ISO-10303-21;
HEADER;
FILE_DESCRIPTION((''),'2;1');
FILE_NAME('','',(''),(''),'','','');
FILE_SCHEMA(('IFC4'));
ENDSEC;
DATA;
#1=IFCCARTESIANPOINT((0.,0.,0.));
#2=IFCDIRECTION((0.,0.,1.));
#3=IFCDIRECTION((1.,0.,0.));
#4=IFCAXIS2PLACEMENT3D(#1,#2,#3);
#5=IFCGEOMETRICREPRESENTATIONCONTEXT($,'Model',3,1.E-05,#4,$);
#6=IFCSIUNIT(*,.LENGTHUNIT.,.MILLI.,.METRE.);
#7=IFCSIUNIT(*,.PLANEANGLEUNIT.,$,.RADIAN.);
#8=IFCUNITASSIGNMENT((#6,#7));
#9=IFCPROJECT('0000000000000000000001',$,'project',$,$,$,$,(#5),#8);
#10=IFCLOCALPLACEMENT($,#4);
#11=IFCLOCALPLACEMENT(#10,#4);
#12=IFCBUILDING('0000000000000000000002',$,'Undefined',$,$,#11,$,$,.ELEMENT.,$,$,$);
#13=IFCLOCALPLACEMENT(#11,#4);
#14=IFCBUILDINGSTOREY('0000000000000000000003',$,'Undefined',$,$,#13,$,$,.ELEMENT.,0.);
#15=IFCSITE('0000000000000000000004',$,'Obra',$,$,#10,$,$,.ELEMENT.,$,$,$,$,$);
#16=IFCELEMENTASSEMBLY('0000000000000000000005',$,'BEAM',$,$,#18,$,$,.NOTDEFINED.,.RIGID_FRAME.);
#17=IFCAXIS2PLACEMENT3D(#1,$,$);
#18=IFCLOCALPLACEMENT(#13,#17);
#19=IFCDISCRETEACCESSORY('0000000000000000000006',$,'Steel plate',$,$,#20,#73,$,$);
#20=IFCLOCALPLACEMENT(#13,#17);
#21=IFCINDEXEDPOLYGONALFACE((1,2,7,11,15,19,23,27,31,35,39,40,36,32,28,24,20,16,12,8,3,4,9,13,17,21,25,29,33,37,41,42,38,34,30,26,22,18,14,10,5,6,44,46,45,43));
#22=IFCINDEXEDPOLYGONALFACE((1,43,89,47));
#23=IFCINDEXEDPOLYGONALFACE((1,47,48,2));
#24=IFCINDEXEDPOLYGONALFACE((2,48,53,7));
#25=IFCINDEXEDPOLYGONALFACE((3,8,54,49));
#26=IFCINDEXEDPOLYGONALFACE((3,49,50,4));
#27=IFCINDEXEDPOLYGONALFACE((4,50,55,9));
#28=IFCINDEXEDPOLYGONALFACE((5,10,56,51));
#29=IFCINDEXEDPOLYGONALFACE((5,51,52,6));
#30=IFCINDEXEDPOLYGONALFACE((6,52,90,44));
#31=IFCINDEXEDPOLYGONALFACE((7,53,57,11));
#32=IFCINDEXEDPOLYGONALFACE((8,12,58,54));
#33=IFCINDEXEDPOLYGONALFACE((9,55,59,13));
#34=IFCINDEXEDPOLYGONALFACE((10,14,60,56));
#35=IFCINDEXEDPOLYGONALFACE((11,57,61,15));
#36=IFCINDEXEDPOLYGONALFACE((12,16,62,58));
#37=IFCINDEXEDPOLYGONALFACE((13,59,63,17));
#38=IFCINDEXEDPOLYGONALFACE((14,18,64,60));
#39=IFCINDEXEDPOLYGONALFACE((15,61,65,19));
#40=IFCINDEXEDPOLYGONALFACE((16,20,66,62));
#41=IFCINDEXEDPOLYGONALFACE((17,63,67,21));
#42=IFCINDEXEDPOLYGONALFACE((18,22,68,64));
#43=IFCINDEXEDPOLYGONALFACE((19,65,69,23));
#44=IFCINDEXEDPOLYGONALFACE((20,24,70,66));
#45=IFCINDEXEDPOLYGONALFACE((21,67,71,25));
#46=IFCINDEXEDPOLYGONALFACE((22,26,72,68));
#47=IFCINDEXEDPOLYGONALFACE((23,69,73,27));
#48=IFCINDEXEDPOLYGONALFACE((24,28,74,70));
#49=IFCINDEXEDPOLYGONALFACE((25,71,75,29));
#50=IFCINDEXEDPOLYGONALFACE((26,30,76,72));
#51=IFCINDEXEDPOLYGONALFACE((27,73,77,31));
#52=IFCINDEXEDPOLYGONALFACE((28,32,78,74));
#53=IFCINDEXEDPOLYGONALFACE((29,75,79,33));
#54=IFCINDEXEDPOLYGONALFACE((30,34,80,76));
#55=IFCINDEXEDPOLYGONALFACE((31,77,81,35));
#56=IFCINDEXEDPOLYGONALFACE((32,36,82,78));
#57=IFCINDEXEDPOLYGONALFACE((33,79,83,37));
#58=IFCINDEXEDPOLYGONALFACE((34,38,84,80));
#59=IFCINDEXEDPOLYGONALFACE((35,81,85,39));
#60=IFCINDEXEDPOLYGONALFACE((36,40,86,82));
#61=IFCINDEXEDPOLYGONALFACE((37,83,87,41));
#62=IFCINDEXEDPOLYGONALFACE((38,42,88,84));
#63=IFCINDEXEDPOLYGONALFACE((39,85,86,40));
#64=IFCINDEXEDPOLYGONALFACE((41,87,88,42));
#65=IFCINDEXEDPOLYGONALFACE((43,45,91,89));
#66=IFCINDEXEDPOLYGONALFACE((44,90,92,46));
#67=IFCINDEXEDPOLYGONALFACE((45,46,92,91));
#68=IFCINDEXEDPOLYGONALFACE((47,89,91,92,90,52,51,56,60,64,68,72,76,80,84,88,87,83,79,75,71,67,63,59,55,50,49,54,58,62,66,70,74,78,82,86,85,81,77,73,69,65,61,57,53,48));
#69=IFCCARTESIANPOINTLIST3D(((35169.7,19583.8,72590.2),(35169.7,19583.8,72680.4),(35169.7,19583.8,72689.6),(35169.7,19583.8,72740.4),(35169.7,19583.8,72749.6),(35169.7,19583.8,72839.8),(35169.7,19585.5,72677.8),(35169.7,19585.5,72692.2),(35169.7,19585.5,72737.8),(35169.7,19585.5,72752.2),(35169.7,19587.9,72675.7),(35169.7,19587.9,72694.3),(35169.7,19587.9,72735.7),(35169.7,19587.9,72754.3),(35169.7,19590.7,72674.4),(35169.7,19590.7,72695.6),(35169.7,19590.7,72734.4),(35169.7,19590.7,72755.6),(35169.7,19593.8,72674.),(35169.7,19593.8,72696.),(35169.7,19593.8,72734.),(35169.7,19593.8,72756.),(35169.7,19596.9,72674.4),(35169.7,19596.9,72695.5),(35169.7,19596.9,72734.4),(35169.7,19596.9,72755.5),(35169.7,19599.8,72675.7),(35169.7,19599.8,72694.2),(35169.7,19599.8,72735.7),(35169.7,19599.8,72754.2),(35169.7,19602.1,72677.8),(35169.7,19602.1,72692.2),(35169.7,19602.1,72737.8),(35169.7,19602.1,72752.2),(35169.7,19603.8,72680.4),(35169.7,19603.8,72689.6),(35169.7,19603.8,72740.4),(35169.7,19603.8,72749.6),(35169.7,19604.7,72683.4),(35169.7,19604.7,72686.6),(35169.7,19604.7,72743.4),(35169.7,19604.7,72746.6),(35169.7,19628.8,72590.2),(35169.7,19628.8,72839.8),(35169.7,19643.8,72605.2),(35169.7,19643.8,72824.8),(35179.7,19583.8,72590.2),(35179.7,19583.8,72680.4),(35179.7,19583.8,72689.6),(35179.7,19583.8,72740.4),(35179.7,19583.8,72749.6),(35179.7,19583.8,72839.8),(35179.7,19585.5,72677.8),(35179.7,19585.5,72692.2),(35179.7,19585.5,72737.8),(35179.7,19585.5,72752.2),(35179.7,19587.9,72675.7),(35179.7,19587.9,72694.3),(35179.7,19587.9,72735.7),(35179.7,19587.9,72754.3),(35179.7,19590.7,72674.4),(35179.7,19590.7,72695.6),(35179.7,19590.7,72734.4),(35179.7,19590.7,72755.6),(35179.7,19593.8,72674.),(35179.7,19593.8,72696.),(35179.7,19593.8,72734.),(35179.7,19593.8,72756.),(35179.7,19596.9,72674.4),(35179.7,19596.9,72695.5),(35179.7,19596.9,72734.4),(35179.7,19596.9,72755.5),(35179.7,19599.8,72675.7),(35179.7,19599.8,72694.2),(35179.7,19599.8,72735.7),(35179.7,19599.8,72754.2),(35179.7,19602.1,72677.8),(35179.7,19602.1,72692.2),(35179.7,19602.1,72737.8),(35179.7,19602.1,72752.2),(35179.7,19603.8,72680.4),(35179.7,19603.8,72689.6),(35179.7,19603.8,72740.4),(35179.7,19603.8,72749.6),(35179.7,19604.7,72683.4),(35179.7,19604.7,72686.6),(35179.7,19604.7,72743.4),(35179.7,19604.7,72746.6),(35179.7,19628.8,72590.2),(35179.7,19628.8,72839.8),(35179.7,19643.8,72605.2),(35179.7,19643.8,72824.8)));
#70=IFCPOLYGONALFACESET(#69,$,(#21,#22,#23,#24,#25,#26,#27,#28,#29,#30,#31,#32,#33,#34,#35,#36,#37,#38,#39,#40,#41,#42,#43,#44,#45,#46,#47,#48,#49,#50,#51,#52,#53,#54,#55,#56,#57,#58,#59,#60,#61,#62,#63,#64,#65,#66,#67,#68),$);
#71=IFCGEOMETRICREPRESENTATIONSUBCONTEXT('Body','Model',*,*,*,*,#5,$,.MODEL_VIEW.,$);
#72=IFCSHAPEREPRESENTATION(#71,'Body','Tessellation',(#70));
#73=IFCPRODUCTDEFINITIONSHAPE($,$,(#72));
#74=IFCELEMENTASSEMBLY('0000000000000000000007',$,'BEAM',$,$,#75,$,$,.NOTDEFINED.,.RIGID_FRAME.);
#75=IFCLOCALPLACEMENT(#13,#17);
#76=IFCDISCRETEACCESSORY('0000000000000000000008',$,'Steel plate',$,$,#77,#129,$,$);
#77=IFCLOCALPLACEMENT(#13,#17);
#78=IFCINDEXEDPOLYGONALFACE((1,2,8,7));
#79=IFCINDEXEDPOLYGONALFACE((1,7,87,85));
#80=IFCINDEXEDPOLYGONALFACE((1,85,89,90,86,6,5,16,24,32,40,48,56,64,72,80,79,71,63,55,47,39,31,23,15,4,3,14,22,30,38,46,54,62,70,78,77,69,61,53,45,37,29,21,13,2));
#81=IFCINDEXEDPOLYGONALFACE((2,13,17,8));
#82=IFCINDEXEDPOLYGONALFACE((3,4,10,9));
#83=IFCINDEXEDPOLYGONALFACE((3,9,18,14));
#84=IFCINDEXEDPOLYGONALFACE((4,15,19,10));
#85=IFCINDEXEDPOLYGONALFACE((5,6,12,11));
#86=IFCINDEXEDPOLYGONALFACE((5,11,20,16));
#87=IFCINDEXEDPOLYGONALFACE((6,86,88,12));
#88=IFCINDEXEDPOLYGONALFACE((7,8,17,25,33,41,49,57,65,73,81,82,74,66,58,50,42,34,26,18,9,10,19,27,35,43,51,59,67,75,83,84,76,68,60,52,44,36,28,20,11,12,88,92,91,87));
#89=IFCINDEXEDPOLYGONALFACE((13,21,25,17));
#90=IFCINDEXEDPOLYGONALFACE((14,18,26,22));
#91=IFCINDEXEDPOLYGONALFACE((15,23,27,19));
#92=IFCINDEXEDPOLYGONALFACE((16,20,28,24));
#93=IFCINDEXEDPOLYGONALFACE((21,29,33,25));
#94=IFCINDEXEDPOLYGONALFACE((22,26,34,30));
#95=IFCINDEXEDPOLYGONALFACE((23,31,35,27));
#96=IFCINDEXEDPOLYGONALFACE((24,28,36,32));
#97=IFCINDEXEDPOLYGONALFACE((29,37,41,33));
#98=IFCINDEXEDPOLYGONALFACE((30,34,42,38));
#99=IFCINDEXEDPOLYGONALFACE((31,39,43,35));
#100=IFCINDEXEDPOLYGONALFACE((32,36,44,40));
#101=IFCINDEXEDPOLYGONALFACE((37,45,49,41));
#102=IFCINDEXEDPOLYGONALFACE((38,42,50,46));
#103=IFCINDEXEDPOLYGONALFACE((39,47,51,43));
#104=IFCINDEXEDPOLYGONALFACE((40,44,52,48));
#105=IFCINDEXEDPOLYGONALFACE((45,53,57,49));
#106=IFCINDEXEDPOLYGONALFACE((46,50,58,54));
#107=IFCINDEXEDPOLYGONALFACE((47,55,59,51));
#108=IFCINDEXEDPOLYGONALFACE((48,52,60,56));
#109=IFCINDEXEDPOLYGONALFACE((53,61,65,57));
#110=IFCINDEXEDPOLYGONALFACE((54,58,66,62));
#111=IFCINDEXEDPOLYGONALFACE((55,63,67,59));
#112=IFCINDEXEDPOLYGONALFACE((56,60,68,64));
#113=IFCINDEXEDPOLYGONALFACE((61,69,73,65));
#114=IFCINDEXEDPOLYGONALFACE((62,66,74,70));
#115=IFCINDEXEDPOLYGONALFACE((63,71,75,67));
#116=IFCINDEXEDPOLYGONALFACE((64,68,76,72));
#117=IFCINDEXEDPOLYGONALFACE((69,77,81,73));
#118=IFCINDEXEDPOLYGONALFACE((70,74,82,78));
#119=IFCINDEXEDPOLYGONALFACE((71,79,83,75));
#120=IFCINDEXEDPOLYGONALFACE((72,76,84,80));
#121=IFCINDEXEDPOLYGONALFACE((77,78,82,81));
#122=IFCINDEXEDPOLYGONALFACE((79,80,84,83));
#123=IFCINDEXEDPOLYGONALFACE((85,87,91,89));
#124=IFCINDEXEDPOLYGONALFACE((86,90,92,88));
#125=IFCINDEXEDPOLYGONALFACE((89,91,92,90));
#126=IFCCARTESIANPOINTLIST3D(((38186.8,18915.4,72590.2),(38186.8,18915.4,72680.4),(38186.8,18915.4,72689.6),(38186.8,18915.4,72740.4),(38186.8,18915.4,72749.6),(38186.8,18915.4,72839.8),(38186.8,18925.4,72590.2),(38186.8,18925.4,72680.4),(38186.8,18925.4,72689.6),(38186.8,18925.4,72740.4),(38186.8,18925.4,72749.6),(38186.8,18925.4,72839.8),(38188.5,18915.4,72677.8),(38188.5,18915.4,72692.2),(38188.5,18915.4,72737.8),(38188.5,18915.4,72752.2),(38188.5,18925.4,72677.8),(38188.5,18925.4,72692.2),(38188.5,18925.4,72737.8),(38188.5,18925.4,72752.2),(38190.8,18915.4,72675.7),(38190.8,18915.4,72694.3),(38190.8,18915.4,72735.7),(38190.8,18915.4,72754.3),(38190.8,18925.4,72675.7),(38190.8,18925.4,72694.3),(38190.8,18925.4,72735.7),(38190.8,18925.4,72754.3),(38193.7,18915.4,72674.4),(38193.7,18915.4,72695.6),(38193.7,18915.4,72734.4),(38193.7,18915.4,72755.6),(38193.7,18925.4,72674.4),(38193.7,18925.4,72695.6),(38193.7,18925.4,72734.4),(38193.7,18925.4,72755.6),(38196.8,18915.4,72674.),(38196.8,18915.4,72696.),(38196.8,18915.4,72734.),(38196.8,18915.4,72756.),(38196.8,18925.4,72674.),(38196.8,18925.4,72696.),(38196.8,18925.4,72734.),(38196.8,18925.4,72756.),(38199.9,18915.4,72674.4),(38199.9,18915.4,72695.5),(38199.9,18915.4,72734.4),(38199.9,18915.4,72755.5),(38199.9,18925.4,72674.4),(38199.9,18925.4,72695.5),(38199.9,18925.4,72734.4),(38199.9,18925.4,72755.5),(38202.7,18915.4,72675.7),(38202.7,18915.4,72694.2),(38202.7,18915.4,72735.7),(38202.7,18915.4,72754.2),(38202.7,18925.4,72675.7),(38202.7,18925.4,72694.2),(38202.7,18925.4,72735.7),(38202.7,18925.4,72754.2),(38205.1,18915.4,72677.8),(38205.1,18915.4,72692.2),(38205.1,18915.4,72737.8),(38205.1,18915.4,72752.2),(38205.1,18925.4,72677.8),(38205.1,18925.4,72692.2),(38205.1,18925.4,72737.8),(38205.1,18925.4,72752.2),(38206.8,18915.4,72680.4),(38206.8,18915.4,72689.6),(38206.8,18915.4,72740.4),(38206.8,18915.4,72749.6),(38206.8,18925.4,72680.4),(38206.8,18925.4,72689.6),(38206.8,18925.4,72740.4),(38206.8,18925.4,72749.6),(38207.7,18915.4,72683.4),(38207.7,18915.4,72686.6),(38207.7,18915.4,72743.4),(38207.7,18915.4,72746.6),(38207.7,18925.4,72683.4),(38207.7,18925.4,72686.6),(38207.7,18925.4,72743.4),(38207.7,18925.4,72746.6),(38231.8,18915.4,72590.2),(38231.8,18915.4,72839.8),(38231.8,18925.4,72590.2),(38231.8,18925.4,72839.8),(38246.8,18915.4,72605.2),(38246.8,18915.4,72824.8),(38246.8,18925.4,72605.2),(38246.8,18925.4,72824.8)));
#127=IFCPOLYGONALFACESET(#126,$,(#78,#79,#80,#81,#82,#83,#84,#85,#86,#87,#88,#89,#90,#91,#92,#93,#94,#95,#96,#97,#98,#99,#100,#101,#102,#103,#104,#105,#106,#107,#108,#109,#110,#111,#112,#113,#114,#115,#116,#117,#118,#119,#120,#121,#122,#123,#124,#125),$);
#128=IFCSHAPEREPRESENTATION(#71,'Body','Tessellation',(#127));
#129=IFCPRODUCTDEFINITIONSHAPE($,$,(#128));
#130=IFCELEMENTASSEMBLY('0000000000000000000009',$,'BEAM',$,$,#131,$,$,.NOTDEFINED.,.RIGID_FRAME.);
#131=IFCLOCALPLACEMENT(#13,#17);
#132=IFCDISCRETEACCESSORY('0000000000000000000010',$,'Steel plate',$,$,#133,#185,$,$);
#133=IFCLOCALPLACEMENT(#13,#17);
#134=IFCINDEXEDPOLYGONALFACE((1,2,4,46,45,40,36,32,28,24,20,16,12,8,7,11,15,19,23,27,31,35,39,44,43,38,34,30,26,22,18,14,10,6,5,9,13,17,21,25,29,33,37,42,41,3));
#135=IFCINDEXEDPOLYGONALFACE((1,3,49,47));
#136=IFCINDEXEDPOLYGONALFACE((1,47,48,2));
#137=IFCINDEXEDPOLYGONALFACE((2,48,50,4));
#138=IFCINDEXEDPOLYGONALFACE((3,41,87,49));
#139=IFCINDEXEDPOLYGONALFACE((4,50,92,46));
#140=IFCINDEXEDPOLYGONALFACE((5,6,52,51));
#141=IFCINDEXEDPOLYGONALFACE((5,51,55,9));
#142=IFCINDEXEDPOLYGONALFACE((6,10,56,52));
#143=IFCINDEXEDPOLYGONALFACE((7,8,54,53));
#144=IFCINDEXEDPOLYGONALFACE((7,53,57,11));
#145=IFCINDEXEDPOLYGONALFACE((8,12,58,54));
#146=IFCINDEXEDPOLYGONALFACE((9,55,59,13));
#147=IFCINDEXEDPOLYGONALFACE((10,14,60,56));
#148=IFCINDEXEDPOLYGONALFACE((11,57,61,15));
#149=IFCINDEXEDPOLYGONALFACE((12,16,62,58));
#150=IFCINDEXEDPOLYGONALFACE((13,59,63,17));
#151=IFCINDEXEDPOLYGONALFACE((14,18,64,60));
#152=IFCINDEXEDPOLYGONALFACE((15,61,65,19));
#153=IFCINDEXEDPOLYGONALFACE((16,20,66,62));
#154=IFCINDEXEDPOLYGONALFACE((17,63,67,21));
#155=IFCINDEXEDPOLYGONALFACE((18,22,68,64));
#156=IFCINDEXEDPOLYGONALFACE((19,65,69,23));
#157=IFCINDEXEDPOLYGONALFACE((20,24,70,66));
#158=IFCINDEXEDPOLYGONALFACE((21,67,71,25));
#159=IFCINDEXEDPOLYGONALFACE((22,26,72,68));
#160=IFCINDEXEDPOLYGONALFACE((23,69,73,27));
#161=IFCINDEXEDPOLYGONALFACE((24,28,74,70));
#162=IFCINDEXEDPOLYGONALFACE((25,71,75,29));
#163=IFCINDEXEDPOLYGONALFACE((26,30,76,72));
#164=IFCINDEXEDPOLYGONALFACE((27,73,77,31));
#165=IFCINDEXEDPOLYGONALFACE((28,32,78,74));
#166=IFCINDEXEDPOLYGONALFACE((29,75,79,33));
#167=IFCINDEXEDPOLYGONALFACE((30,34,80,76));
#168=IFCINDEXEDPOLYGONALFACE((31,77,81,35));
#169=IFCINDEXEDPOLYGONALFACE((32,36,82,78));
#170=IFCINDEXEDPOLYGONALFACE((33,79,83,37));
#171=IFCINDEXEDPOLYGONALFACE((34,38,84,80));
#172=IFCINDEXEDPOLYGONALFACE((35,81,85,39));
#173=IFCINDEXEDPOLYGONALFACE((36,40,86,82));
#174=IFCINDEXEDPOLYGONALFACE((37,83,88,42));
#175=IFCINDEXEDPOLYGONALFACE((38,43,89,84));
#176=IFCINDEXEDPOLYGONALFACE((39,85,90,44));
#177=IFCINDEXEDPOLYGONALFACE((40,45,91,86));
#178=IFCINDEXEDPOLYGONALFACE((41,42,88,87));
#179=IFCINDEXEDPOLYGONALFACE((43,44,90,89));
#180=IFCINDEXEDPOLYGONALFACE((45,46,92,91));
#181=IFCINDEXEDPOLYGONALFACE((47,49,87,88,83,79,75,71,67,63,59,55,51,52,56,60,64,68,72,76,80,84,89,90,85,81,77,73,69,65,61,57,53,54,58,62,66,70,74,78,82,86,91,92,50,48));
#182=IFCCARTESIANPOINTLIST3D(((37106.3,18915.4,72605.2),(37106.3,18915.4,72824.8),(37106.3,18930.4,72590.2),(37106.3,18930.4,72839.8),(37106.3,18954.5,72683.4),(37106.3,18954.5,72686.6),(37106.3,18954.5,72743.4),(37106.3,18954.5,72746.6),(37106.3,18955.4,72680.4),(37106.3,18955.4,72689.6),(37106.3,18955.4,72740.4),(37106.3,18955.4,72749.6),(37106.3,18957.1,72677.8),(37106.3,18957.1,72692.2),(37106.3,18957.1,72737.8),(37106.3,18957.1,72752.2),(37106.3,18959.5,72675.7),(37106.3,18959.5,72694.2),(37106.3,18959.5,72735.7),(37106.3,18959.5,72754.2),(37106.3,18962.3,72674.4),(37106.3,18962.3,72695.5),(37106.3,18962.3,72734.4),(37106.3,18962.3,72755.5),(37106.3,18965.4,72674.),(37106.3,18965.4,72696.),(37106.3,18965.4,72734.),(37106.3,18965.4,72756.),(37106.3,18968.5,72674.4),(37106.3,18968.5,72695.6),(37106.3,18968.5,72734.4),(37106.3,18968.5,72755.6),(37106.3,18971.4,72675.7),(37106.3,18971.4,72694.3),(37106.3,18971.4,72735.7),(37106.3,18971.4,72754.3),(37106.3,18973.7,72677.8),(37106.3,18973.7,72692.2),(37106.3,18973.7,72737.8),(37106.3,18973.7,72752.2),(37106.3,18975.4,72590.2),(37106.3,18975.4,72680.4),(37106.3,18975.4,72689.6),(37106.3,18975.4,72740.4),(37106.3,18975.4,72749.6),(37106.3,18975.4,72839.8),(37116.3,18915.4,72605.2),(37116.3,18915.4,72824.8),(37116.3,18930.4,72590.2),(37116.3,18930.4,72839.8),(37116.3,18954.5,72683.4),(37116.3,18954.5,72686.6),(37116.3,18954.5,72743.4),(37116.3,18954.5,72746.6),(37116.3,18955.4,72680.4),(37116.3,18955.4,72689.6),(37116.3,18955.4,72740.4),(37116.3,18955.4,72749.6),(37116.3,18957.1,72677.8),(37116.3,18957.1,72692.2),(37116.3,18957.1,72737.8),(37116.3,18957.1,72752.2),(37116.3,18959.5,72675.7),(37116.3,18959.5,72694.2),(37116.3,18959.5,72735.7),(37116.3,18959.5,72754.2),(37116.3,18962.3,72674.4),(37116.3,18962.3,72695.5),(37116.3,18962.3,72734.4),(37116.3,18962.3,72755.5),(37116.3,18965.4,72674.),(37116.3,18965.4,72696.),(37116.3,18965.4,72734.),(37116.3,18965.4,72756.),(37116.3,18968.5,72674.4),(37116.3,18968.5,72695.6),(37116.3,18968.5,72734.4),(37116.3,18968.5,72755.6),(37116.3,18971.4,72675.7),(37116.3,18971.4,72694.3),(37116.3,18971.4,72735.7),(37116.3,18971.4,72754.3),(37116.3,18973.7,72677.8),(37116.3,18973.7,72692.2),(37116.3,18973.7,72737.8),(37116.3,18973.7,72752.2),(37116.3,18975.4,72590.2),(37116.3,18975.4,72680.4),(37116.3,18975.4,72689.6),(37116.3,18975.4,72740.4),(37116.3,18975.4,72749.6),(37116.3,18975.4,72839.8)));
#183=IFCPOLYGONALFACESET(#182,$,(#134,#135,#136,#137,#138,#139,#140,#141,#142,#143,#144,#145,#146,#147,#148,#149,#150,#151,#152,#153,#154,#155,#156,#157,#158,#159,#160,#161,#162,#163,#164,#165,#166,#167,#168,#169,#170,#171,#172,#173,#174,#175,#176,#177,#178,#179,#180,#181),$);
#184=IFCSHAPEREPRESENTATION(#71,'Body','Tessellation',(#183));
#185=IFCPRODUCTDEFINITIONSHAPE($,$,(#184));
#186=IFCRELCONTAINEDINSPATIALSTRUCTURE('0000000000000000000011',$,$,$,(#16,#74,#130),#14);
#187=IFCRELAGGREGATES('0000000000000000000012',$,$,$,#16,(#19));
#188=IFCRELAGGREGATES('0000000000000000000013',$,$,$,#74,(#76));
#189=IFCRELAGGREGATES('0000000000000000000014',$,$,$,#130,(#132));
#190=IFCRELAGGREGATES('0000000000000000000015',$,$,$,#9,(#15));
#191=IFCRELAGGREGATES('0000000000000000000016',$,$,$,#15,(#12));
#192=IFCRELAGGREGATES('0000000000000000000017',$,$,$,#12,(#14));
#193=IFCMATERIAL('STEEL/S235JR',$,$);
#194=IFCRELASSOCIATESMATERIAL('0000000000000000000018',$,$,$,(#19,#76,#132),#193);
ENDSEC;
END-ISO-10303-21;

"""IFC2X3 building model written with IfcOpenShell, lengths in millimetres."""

from ifc_helpers import new_model, si_unit, frame, origin_with_axes, origin_2d_with_axis, place, context, subcontext, project, spatial, polyline, circle, outline, extrude, source, transform, mapped, material, element, aggregate, save


model = new_model("IFC2X3")

# Units and contexts
model_context = context("Model", 3, precision=1e-05, world=origin_with_axes())
body_context = subcontext(model_context, "Body", "Model", "MODEL_VIEW")
ifc_project = project(units=[si_unit("LENGTHUNIT", "METRE", prefix="MILLI"), si_unit("PLANEANGLEUNIT", "RADIAN")], contexts=[model_context])

# Site, building, storey
site_placement = place(None, origin_with_axes())
site = spatial("IfcSite", under=ifc_project, at=site_placement, Name="Obra", CompositionType="ELEMENT")
building_placement = place(site_placement, origin_with_axes())
building = spatial("IfcBuilding", under=site, at=building_placement, Name="Undefined", CompositionType="ELEMENT")
storey_placement = place(building_placement, origin_with_axes())
storey = spatial("IfcBuildingStorey", under=building, at=storey_placement, Name="Undefined", CompositionType="ELEMENT", Elevation=0.0)

# Shared definitions
ifc_material = material(Name="STEEL/S235JR")

# Element assemblies, discrete accessories, openings
assembly_1_placement = place(storey_placement, origin_with_axes())
assembly_1 = element("IfcElementAssembly", 1, at=assembly_1_placement, inside=storey, Name="BEAM", AssemblyPlace="NOTDEFINED", PredefinedType="RIGID_FRAME")
discrete_accessory_1_placement = place(assembly_1_placement, frame((35174.7, 19583.8, 72590.2), z_axis=(1.0, 0.0, 0.0), x_axis=(0.0, 1.0, 0.0)))
discrete_accessory_1 = element("IfcDiscreteAccessory", 2, at=discrete_accessory_1_placement, material=ifc_material, Name="Steel plate", context=body_context, shape_type="SweptSolid", body=[
    extrude(outline(polyline([(0.0, 0.0), (45.0, 0.0), (60.0, 15.0), (60.0, 234.6), (45.0, 249.6), (0.0, 249.6), (0.0, 0.0)])), frame((0.0, 0.0, -5.0), z_axis=(0.0, 0.0, 1.0), x_axis=(1.0, 0.0, 0.0)), (0.0, 0.0, 1.0), 10.0),
])
shared_shape_1 = source(origin_with_axes(), body_context, "Body", "SweptSolid", [
    extrude(circle(Radius=11.0, at=origin_2d_with_axis()), frame((0.0, -13.4, 0.0), z_axis=(0.0, 1.0, 0.0), x_axis=(1.0, 0.0, 0.0)), (0.0, 0.0, 1.0), 10.2),
])
opening_1_placement = place(assembly_1_placement, frame((35183.0, 19633.8, 72850.0), z_axis=(0.0, -1.0, 0.0), x_axis=(0.0, 0.0, -1.0)))
element("IfcOpeningElement", 3, at=opening_1_placement, cuts=discrete_accessory_1, ObjectType="Opening", context=body_context, shape_type="MappedRepresentation", body=[
    mapped(shared_shape_1, transform((105.0, 0.0, 40.0))),
    mapped(shared_shape_1, transform((165.0, 0.0, 40.0))),
])
aggregate(assembly_1, [discrete_accessory_1])
assembly_2_placement = place(storey_placement, origin_with_axes())
assembly_2 = element("IfcElementAssembly", 4, at=assembly_2_placement, inside=storey, Name="BEAM", AssemblyPlace="NOTDEFINED", PredefinedType="RIGID_FRAME")
discrete_accessory_2_placement = place(assembly_2_placement, frame((38186.8, 18920.4, 72590.2), z_axis=(0.0, -1.0, 0.0), x_axis=(1.0, 0.0, 0.0)))
discrete_accessory_2 = element("IfcDiscreteAccessory", 5, at=discrete_accessory_2_placement, material=ifc_material, Name="Steel plate", context=body_context, shape_type="SweptSolid", body=[
    extrude(outline(polyline([(0.0, 0.0), (45.0, 0.0), (60.0, 15.0), (60.0, 234.6), (45.0, 249.6), (0.0, 249.6), (0.0, 0.0)])), frame((0.0, 0.0, -5.0), z_axis=(0.0, 0.0, 1.0), x_axis=(1.0, 0.0, 0.0)), (0.0, 0.0, 1.0), 10.0),
])
opening_2_placement = place(assembly_2_placement, frame((38236.8, 18912.1, 72850.0), z_axis=(-1.0, 0.0, 0.0), x_axis=(0.0, 0.0, -1.0)))
element("IfcOpeningElement", 6, at=opening_2_placement, cuts=discrete_accessory_2, ObjectType="Opening", context=body_context, shape_type="MappedRepresentation", body=[
    mapped(shared_shape_1, transform((105.0, 0.0, 40.0))),
    mapped(shared_shape_1, transform((165.0, 0.0, 40.0))),
])
aggregate(assembly_2, [discrete_accessory_2])

# Element assembly, discrete accessory, opening
assembly_3_placement = place(storey_placement, origin_with_axes())
assembly_3 = element("IfcElementAssembly", 7, at=assembly_3_placement, inside=storey, Name="BEAM", AssemblyPlace="NOTDEFINED", PredefinedType="RIGID_FRAME")
discrete_accessory_3_placement = place(assembly_3_placement, frame((37111.3, 18975.4, 72590.2), z_axis=(-1.0, 0.0, 0.0), x_axis=(0.0, -1.0, 0.0)))
discrete_accessory_3 = element("IfcDiscreteAccessory", 8, at=discrete_accessory_3_placement, material=ifc_material, Name="Steel plate", context=body_context, shape_type="SweptSolid", body=[
    extrude(outline(polyline([(0.0, 0.0), (45.0, 0.0), (60.0, 15.0), (60.0, 234.6), (45.0, 249.6), (0.0, 249.6), (0.0, 0.0)])), frame((0.0, 0.0, -5.0), z_axis=(0.0, 0.0, 1.0), x_axis=(1.0, 0.0, 0.0)), (0.0, 0.0, 1.0), 10.0),
])
opening_3_placement = place(assembly_3_placement, frame((37103.0, 18925.4, 72850.0), z_axis=(0.0, 1.0, 0.0), x_axis=(0.0, 0.0, -1.0)))
element("IfcOpeningElement", 9, at=opening_3_placement, cuts=discrete_accessory_3, ObjectType="Opening", context=body_context, shape_type="MappedRepresentation", body=[
    mapped(shared_shape_1, transform((105.0, 0.0, 40.0))),
    mapped(shared_shape_1, transform((165.0, 0.0, 40.0))),
])
aggregate(assembly_3, [discrete_accessory_3])

save(model, "model.ifc")
